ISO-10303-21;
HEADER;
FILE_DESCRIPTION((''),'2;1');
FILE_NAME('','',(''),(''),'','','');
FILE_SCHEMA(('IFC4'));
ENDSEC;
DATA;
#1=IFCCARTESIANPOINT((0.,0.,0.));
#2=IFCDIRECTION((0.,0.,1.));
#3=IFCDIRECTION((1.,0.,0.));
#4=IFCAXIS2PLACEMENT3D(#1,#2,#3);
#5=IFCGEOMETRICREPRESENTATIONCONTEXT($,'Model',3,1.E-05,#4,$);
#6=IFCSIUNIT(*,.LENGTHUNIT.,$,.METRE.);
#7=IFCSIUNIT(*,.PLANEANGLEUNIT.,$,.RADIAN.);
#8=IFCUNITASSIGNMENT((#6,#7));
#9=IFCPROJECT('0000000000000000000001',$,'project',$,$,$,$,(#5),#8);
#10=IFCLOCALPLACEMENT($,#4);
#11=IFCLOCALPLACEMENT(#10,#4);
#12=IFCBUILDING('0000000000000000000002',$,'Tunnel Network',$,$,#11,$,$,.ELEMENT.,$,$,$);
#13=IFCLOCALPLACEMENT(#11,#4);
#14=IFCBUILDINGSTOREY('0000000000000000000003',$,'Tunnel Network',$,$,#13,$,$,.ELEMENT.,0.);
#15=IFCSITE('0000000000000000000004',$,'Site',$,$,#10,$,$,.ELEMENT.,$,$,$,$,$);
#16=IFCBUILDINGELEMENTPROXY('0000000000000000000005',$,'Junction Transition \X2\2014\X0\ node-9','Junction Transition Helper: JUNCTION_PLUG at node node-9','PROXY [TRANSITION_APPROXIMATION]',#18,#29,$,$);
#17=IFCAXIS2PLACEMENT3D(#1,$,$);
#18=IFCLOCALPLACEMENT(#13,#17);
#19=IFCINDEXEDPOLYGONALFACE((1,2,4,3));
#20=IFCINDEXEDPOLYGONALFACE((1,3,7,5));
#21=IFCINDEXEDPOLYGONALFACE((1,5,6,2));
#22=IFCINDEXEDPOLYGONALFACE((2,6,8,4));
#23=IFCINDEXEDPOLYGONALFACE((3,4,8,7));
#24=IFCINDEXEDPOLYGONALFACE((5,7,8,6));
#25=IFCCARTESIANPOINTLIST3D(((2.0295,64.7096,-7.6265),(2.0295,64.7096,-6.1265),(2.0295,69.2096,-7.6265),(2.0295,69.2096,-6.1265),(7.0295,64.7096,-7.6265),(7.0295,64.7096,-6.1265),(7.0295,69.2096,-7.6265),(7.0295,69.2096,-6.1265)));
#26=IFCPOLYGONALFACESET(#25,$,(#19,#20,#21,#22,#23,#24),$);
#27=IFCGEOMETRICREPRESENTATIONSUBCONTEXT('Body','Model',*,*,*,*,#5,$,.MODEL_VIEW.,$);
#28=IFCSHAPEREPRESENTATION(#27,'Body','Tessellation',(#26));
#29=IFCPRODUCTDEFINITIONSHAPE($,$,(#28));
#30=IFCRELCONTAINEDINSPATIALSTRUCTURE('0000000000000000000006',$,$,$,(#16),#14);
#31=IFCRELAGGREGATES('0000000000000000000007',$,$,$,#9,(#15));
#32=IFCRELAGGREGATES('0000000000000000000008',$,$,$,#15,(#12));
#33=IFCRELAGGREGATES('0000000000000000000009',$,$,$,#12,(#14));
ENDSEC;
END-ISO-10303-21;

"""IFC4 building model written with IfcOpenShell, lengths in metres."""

from ifc_helpers import new_model, si_unit, frame, origin_with_axes, origin_2d_with_axis, place, context, subcontext, project, spatial, rectangle, extrude, element, save


model = new_model("IFC4")

# Units and contexts
model_context = context("Model", 3, precision=1e-05, world=origin_with_axes())
body_context = subcontext(model_context, "Body", "Model", "MODEL_VIEW")
ifc_project = project(units=[si_unit("LENGTHUNIT", "METRE"), si_unit("PLANEANGLEUNIT", "RADIAN")], contexts=[model_context])

# Site, building, storey
site_placement = place(None, origin_with_axes())
site = spatial("IfcSite", under=ifc_project, at=site_placement, Name="Site", CompositionType="ELEMENT")
building_placement = place(site_placement, origin_with_axes())
building = spatial("IfcBuilding", under=site, at=building_placement, Name="Tunnel Network", CompositionType="ELEMENT")
storey_placement = place(building_placement, origin_with_axes())
storey = spatial("IfcBuildingStorey", under=building, at=storey_placement, Name="Tunnel Network", CompositionType="ELEMENT", Elevation=0.0)

# Building element proxy
proxy_placement = place(storey_placement, frame((4.5295, 66.9596, -7.6265), z_axis=(0.0, 0.0, 1.0), x_axis=(1.0, 0.0, 0.0)))
element("IfcBuildingElementProxy", 1, at=proxy_placement, inside=storey, Name="Junction Transition — node-9", Description="Junction Transition Helper: JUNCTION_PLUG at node node-9", ObjectType="PROXY [TRANSITION_APPROXIMATION]", context=body_context, shape_type="SweptSolid", body=[
    extrude(rectangle(XDim=5.0, YDim=4.5, at=origin_2d_with_axis()), origin_with_axes(), (0.0, 0.0, 1.0), 1.5),
])

save(model, "model.ifc")
